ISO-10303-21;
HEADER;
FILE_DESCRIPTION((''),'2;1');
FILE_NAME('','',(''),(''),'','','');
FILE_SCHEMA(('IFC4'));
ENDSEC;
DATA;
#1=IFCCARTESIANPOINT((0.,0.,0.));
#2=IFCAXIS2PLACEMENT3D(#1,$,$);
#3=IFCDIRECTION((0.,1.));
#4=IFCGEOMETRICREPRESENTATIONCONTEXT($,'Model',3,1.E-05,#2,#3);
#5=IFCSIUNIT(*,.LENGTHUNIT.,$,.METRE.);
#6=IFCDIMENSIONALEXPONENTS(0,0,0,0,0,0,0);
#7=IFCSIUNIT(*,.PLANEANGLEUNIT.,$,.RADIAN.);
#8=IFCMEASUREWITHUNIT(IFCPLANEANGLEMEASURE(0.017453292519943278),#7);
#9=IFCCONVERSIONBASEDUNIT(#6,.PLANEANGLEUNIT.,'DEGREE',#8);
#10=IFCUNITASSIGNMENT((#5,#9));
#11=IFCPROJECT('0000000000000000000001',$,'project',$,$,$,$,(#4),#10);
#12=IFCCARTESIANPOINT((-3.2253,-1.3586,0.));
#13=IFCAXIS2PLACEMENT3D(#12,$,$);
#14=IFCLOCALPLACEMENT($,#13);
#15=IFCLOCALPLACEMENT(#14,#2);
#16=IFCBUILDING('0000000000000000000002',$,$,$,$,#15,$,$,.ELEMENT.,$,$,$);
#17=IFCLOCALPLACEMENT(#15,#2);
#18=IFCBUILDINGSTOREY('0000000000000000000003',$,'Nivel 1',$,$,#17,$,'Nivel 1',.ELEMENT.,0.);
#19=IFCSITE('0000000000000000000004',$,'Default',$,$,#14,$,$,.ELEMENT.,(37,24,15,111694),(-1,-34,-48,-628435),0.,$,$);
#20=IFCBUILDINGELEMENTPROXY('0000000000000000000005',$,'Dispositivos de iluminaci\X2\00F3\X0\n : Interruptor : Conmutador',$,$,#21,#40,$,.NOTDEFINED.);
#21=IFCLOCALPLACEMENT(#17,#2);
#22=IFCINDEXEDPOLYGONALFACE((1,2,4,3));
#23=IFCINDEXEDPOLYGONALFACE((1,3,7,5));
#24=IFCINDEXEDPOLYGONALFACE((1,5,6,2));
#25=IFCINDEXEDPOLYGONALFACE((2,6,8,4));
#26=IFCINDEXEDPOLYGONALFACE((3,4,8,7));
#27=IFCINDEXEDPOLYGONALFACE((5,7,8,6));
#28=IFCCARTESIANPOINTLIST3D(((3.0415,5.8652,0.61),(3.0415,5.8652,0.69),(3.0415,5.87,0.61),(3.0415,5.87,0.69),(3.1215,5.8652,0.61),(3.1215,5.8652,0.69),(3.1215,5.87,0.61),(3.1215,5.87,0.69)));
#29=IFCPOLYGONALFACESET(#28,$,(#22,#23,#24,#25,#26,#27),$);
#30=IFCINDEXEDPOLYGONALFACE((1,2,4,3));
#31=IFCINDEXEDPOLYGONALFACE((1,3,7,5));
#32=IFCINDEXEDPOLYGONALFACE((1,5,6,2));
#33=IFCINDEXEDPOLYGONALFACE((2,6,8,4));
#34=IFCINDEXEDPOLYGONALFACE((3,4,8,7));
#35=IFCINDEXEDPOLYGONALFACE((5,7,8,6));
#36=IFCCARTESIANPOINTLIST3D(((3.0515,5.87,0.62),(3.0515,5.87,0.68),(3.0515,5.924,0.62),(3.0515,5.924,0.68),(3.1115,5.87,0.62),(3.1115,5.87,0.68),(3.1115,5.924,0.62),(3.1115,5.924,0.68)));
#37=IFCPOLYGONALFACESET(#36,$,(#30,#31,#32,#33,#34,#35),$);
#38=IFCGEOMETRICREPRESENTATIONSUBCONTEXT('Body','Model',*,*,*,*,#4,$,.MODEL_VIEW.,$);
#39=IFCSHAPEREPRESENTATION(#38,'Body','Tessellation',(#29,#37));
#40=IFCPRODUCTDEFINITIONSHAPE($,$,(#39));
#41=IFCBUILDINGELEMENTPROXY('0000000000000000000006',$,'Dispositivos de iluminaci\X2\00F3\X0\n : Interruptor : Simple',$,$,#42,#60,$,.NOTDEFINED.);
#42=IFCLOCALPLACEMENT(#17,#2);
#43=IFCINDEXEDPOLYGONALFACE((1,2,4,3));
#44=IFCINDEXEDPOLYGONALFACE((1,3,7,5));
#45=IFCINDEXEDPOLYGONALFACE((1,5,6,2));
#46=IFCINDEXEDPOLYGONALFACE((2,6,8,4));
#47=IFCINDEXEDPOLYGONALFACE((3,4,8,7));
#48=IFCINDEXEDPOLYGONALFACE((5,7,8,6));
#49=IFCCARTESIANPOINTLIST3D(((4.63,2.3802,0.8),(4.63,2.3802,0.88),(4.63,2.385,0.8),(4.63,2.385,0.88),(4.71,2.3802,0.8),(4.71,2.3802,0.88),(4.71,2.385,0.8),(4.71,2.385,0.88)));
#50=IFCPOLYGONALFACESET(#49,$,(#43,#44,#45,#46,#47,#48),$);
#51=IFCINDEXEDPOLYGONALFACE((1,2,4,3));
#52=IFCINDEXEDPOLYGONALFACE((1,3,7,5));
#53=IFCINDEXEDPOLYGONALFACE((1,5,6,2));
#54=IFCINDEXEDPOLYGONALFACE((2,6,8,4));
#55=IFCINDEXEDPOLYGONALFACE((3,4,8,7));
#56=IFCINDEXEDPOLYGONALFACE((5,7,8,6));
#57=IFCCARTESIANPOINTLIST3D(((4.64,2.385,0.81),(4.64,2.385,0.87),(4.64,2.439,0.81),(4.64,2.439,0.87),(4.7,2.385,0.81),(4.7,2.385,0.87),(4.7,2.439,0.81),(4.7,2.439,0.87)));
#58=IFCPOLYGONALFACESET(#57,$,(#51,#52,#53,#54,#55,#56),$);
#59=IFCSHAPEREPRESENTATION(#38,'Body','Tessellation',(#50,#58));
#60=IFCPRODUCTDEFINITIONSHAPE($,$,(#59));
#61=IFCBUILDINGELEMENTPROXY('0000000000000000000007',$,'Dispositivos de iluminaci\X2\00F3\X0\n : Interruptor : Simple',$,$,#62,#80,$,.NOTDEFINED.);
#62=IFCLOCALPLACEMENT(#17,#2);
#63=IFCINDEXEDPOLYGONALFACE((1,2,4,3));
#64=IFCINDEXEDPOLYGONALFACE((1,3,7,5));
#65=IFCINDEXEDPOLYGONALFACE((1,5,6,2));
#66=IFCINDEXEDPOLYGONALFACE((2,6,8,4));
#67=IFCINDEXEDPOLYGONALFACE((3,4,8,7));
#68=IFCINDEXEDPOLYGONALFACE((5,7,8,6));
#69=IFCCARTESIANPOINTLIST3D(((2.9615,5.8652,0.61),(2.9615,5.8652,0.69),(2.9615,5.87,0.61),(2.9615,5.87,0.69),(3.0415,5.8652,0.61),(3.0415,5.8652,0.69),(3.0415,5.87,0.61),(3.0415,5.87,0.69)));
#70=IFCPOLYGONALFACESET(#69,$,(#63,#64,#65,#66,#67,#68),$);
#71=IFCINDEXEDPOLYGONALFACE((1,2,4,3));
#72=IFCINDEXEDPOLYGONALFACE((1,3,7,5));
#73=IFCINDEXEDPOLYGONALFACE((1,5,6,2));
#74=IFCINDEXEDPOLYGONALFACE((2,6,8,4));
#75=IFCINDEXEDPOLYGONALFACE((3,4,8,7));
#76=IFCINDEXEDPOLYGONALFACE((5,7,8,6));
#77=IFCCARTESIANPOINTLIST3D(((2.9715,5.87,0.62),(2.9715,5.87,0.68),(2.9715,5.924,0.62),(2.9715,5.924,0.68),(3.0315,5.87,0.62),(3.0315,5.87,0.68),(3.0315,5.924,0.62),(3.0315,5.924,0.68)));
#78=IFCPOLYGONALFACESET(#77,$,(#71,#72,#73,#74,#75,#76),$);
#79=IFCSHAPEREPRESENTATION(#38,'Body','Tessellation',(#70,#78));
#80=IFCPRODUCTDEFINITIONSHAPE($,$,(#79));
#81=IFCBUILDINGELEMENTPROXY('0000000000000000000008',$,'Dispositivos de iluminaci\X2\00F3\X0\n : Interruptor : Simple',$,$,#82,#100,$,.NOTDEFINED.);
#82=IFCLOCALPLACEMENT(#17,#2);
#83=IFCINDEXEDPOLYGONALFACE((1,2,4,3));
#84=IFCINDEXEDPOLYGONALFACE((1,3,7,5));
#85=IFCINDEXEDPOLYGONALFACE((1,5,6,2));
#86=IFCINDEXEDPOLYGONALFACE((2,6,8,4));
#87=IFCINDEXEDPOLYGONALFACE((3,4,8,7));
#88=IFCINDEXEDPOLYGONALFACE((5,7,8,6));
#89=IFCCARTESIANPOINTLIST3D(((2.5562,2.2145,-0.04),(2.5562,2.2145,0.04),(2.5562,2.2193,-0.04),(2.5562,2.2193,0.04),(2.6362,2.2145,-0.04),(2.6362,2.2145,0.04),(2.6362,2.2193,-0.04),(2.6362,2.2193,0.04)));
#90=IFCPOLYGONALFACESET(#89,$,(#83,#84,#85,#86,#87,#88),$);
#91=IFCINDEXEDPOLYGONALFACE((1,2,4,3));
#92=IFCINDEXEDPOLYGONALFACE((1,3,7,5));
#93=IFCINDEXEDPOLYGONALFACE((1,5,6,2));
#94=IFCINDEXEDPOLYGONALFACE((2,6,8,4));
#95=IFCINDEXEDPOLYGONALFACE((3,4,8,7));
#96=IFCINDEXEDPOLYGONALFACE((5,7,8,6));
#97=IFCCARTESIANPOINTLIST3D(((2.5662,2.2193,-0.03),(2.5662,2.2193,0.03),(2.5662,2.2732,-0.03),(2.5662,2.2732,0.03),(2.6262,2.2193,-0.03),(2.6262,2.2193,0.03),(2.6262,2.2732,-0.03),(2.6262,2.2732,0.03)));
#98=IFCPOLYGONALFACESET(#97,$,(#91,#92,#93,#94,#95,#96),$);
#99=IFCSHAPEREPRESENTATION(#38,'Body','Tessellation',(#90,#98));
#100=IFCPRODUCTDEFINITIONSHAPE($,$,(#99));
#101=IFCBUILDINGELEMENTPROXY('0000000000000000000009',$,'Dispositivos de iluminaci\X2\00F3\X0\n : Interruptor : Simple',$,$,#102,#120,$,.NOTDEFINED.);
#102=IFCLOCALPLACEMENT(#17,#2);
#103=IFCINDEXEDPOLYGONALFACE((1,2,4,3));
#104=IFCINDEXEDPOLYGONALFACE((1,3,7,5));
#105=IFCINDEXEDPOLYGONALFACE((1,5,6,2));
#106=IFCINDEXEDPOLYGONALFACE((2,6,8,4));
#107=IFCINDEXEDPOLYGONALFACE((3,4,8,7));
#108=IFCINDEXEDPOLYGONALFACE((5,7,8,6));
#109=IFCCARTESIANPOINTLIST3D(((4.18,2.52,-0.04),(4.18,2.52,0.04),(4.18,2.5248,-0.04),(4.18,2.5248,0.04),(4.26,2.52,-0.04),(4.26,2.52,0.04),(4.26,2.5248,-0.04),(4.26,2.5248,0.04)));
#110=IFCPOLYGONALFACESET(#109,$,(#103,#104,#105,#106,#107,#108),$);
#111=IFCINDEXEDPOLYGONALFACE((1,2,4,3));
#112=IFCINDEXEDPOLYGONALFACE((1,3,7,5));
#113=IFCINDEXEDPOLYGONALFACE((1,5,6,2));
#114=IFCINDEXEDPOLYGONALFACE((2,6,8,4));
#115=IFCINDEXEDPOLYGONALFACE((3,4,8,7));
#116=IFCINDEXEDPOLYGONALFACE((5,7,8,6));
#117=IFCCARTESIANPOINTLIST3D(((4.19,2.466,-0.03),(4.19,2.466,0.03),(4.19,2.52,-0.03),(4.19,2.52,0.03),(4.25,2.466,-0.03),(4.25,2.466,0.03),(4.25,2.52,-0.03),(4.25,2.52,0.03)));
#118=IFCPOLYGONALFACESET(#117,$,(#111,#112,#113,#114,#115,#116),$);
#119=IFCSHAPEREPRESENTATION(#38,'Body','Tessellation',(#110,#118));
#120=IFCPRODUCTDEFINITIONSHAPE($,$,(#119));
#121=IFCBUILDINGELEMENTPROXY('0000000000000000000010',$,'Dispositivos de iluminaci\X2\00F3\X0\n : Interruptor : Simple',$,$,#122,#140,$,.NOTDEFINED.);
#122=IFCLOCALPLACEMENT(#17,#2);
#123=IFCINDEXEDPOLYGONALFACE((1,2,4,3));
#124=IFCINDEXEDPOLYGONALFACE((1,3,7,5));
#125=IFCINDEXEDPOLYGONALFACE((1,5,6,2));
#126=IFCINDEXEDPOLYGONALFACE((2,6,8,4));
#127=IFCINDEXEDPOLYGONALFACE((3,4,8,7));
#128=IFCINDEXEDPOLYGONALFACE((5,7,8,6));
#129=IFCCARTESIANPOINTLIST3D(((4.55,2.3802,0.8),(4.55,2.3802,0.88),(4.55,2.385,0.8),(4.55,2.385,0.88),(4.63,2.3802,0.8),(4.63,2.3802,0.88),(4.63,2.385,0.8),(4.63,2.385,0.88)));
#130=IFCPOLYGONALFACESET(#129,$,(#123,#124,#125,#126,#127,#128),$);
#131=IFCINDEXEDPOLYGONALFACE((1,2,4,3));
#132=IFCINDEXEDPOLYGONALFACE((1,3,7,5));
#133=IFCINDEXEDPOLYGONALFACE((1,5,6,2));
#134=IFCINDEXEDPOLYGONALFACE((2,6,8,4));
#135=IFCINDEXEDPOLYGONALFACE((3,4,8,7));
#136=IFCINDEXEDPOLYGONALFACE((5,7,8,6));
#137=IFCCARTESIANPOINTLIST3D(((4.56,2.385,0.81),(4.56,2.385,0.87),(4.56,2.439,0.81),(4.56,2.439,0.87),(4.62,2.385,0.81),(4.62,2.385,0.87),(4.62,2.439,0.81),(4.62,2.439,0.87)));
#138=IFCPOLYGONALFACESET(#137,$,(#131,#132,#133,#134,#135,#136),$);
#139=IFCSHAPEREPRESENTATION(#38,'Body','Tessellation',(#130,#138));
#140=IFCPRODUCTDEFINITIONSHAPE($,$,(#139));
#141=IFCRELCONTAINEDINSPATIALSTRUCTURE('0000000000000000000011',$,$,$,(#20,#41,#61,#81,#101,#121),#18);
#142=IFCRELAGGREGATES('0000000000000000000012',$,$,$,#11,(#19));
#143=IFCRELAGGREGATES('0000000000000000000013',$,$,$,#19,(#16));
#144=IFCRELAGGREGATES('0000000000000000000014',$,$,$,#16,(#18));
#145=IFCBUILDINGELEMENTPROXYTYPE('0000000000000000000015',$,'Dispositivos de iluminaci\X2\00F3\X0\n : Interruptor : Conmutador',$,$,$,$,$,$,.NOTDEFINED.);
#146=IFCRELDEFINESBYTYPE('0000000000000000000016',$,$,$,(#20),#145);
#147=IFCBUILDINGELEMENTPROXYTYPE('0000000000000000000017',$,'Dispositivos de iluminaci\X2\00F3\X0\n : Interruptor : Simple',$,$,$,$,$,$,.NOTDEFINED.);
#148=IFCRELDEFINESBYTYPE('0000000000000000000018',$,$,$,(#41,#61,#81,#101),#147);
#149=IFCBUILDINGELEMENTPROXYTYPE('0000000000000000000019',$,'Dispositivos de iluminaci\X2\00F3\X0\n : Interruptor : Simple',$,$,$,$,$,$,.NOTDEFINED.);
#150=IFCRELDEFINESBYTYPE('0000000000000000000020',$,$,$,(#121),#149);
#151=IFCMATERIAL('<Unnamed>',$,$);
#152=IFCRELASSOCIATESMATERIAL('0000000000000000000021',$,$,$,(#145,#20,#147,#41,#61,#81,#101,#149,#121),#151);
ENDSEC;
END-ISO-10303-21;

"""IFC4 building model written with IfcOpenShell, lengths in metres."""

from ifc_helpers import new_model, entity, si_unit, converted_unit, direction, frame, origin, place, context, subcontext, project, spatial, indexed_curve, outline, extrude, source, transform, mapped, material, type_object, type_shapes, element, save


model = new_model("IFC4")

# Units and contexts
model_context = context("Model", 3, precision=1e-05, world=origin(), true_north=direction((0.0, 1.0)))
body_context = subcontext(model_context, "Body", "Model", "MODEL_VIEW")
ifc_project = project(units=[si_unit("LENGTHUNIT", "METRE"), converted_unit("PLANEANGLEUNIT", "DEGREE", entity("IfcPlaneAngleMeasure", 0.017453292519943278), si_unit("PLANEANGLEUNIT", "RADIAN"), dimensions=[0, 0, 0, 0, 0, 0, 0])], contexts=[model_context])

# Site, building, storey
site_placement = place(None, frame((-3.2253, -1.3586, 0.0)))
site = spatial("IfcSite", under=ifc_project, at=site_placement, Name="Default", CompositionType="ELEMENT", RefLatitude=(37, 24, 15, 111694), RefLongitude=(-1, -34, -48, -628435), RefElevation=0.0)
building_placement = place(site_placement, origin())
building = spatial("IfcBuilding", under=site, at=building_placement, CompositionType="ELEMENT")
storey_placement = place(building_placement, origin())
storey = spatial("IfcBuildingStorey", under=building, at=storey_placement, Name="Nivel 1", LongName="Nivel 1", CompositionType="ELEMENT", Elevation=0.0)

# Shared definitions
ifc_material_1 = material(Name="<Unnamed>")

# Building element proxies
building_element_proxy_type_1 = type_object("IfcBuildingElementProxyType", Name="Dispositivos de iluminación : Interruptor : Conmutador", PredefinedType="NOTDEFINED", material=ifc_material_1)
shared_shape_1 = source(origin(), body_context, "Body", "SweptSolid", [
    extrude(outline(indexed_curve([(-0.04, -0.04), (0.04, -0.04), (0.04, 0.04), (-0.04, 0.04), (-0.04, -0.04)], self_intersect=False)), frame((0.0, 0.0, 0.0), z_axis=(0.0, 0.0, 1.0), x_axis=(0.0, -1.0, 0.0)), (0.0, 0.0, 1.0), 0.0048),
    extrude(outline(indexed_curve([(-0.03, -0.03), (0.03, -0.03), (0.03, 0.03), (-0.03, 0.03), (-0.03, -0.03)], self_intersect=False)), frame((0.0, 0.0, -0.054), z_axis=(0.0, 0.0, 1.0), x_axis=(-1.0, 0.0, 0.0)), (0.0, 0.0, 1.0), 0.054),
])
type_shapes(building_element_proxy_type_1, [shared_shape_1])
for number, where, z_axis, x_axis, name in (
    (1, (3.0815, 5.87, 0.65), (0.0, -1.0, 0.0), (1.0, 0.0, 0.0), "Dispositivos de iluminación : Interruptor : Conmutador"),
):
    element("IfcBuildingElementProxy", number, at=place(storey_placement, frame(where, z_axis=z_axis, x_axis=x_axis)), inside=storey, type_object=building_element_proxy_type_1, material=ifc_material_1, Name=name, PredefinedType="NOTDEFINED", context=body_context, shape_type="MappedRepresentation", body=[
        mapped(shared_shape_1, transform((0.0, 0.0, 0.0), scale=1.0)),
    ])
building_element_proxy_type_2 = type_object("IfcBuildingElementProxyType", Name="Dispositivos de iluminación : Interruptor : Simple", PredefinedType="NOTDEFINED", material=ifc_material_1)
shared_shape_2 = source(origin(), body_context, "Body", "SweptSolid", [
    extrude(outline(indexed_curve([(-0.04, -0.04), (0.04, -0.04), (0.04, 0.04), (-0.04, 0.04), (-0.04, -0.04)], self_intersect=False)), frame((0.0, 0.0, 0.0), z_axis=(0.0, 0.0, 1.0), x_axis=(0.0, -1.0, 0.0)), (0.0, 0.0, 1.0), 0.0048),
    extrude(outline(indexed_curve([(-0.03, -0.03), (0.03, -0.03), (0.03, 0.03), (-0.03, 0.03), (-0.03, -0.03)], self_intersect=False)), frame((0.0, 0.0, -0.054), z_axis=(0.0, 0.0, 1.0), x_axis=(-1.0, 0.0, 0.0)), (0.0, 0.0, 1.0), 0.054),
])
type_shapes(building_element_proxy_type_2, [shared_shape_2])
for number, where, z_axis, x_axis, name in (
    (2, (4.67, 2.385, 0.84), (0.0, -1.0, 0.0), (1.0, 0.0, 0.0), "Dispositivos de iluminación : Interruptor : Simple"),
    (3, (3.0015, 5.87, 0.65), (0.0, -1.0, 0.0), (1.0, 0.0, 0.0), "Dispositivos de iluminación : Interruptor : Simple"),
    (4, (2.5962, 2.2193, 0.0), (0.0, -1.0, 0.0), (1.0, 0.0, 0.0), "Dispositivos de iluminación : Interruptor : Simple"),
    (5, (4.22, 2.52, 0.0), (0.0, 1.0, 0.0), (-1.0, 0.0, 0.0), "Dispositivos de iluminación : Interruptor : Simple"),
):
    element("IfcBuildingElementProxy", number, at=place(storey_placement, frame(where, z_axis=z_axis, x_axis=x_axis)), inside=storey, type_object=building_element_proxy_type_2, material=ifc_material_1, Name=name, PredefinedType="NOTDEFINED", context=body_context, shape_type="MappedRepresentation", body=[
        mapped(shared_shape_2, transform((0.0, 0.0, 0.0), scale=1.0)),
    ])
building_element_proxy_type_3 = type_object("IfcBuildingElementProxyType", Name="Dispositivos de iluminación : Interruptor : Simple", PredefinedType="NOTDEFINED", material=ifc_material_1)
shared_shape_3 = source(origin(), body_context, "Body", "SweptSolid", [
    extrude(outline(indexed_curve([(-0.04, -0.04), (0.04, -0.04), (0.04, 0.04), (-0.04, 0.04), (-0.04, -0.04)], self_intersect=False)), frame((0.0, 0.0, 0.0), z_axis=(0.0, 0.0, 1.0), x_axis=(0.0, -1.0, 0.0)), (0.0, 0.0, 1.0), 0.0048),
    extrude(outline(indexed_curve([(-0.03, -0.03), (0.03, -0.03), (0.03, 0.03), (-0.03, 0.03), (-0.03, -0.03)], self_intersect=False)), frame((0.0, 0.0, -0.054), z_axis=(0.0, 0.0, 1.0), x_axis=(-1.0, 0.0, 0.0)), (0.0, 0.0, 1.0), 0.054),
])
type_shapes(building_element_proxy_type_3, [shared_shape_3])
proxy_1_placement = place(storey_placement, frame((4.59, 2.385, 0.84), z_axis=(0.0, -1.0, 0.0), x_axis=(1.0, 0.0, 0.0)))
element("IfcBuildingElementProxy", 6, at=proxy_1_placement, inside=storey, type_object=building_element_proxy_type_3, material=ifc_material_1, Name="Dispositivos de iluminación : Interruptor : Simple", PredefinedType="NOTDEFINED", context=body_context, shape_type="MappedRepresentation", body=[
    mapped(shared_shape_3, transform((0.0, 0.0, 0.0), scale=1.0)),
])

save(model, "model.ifc")
